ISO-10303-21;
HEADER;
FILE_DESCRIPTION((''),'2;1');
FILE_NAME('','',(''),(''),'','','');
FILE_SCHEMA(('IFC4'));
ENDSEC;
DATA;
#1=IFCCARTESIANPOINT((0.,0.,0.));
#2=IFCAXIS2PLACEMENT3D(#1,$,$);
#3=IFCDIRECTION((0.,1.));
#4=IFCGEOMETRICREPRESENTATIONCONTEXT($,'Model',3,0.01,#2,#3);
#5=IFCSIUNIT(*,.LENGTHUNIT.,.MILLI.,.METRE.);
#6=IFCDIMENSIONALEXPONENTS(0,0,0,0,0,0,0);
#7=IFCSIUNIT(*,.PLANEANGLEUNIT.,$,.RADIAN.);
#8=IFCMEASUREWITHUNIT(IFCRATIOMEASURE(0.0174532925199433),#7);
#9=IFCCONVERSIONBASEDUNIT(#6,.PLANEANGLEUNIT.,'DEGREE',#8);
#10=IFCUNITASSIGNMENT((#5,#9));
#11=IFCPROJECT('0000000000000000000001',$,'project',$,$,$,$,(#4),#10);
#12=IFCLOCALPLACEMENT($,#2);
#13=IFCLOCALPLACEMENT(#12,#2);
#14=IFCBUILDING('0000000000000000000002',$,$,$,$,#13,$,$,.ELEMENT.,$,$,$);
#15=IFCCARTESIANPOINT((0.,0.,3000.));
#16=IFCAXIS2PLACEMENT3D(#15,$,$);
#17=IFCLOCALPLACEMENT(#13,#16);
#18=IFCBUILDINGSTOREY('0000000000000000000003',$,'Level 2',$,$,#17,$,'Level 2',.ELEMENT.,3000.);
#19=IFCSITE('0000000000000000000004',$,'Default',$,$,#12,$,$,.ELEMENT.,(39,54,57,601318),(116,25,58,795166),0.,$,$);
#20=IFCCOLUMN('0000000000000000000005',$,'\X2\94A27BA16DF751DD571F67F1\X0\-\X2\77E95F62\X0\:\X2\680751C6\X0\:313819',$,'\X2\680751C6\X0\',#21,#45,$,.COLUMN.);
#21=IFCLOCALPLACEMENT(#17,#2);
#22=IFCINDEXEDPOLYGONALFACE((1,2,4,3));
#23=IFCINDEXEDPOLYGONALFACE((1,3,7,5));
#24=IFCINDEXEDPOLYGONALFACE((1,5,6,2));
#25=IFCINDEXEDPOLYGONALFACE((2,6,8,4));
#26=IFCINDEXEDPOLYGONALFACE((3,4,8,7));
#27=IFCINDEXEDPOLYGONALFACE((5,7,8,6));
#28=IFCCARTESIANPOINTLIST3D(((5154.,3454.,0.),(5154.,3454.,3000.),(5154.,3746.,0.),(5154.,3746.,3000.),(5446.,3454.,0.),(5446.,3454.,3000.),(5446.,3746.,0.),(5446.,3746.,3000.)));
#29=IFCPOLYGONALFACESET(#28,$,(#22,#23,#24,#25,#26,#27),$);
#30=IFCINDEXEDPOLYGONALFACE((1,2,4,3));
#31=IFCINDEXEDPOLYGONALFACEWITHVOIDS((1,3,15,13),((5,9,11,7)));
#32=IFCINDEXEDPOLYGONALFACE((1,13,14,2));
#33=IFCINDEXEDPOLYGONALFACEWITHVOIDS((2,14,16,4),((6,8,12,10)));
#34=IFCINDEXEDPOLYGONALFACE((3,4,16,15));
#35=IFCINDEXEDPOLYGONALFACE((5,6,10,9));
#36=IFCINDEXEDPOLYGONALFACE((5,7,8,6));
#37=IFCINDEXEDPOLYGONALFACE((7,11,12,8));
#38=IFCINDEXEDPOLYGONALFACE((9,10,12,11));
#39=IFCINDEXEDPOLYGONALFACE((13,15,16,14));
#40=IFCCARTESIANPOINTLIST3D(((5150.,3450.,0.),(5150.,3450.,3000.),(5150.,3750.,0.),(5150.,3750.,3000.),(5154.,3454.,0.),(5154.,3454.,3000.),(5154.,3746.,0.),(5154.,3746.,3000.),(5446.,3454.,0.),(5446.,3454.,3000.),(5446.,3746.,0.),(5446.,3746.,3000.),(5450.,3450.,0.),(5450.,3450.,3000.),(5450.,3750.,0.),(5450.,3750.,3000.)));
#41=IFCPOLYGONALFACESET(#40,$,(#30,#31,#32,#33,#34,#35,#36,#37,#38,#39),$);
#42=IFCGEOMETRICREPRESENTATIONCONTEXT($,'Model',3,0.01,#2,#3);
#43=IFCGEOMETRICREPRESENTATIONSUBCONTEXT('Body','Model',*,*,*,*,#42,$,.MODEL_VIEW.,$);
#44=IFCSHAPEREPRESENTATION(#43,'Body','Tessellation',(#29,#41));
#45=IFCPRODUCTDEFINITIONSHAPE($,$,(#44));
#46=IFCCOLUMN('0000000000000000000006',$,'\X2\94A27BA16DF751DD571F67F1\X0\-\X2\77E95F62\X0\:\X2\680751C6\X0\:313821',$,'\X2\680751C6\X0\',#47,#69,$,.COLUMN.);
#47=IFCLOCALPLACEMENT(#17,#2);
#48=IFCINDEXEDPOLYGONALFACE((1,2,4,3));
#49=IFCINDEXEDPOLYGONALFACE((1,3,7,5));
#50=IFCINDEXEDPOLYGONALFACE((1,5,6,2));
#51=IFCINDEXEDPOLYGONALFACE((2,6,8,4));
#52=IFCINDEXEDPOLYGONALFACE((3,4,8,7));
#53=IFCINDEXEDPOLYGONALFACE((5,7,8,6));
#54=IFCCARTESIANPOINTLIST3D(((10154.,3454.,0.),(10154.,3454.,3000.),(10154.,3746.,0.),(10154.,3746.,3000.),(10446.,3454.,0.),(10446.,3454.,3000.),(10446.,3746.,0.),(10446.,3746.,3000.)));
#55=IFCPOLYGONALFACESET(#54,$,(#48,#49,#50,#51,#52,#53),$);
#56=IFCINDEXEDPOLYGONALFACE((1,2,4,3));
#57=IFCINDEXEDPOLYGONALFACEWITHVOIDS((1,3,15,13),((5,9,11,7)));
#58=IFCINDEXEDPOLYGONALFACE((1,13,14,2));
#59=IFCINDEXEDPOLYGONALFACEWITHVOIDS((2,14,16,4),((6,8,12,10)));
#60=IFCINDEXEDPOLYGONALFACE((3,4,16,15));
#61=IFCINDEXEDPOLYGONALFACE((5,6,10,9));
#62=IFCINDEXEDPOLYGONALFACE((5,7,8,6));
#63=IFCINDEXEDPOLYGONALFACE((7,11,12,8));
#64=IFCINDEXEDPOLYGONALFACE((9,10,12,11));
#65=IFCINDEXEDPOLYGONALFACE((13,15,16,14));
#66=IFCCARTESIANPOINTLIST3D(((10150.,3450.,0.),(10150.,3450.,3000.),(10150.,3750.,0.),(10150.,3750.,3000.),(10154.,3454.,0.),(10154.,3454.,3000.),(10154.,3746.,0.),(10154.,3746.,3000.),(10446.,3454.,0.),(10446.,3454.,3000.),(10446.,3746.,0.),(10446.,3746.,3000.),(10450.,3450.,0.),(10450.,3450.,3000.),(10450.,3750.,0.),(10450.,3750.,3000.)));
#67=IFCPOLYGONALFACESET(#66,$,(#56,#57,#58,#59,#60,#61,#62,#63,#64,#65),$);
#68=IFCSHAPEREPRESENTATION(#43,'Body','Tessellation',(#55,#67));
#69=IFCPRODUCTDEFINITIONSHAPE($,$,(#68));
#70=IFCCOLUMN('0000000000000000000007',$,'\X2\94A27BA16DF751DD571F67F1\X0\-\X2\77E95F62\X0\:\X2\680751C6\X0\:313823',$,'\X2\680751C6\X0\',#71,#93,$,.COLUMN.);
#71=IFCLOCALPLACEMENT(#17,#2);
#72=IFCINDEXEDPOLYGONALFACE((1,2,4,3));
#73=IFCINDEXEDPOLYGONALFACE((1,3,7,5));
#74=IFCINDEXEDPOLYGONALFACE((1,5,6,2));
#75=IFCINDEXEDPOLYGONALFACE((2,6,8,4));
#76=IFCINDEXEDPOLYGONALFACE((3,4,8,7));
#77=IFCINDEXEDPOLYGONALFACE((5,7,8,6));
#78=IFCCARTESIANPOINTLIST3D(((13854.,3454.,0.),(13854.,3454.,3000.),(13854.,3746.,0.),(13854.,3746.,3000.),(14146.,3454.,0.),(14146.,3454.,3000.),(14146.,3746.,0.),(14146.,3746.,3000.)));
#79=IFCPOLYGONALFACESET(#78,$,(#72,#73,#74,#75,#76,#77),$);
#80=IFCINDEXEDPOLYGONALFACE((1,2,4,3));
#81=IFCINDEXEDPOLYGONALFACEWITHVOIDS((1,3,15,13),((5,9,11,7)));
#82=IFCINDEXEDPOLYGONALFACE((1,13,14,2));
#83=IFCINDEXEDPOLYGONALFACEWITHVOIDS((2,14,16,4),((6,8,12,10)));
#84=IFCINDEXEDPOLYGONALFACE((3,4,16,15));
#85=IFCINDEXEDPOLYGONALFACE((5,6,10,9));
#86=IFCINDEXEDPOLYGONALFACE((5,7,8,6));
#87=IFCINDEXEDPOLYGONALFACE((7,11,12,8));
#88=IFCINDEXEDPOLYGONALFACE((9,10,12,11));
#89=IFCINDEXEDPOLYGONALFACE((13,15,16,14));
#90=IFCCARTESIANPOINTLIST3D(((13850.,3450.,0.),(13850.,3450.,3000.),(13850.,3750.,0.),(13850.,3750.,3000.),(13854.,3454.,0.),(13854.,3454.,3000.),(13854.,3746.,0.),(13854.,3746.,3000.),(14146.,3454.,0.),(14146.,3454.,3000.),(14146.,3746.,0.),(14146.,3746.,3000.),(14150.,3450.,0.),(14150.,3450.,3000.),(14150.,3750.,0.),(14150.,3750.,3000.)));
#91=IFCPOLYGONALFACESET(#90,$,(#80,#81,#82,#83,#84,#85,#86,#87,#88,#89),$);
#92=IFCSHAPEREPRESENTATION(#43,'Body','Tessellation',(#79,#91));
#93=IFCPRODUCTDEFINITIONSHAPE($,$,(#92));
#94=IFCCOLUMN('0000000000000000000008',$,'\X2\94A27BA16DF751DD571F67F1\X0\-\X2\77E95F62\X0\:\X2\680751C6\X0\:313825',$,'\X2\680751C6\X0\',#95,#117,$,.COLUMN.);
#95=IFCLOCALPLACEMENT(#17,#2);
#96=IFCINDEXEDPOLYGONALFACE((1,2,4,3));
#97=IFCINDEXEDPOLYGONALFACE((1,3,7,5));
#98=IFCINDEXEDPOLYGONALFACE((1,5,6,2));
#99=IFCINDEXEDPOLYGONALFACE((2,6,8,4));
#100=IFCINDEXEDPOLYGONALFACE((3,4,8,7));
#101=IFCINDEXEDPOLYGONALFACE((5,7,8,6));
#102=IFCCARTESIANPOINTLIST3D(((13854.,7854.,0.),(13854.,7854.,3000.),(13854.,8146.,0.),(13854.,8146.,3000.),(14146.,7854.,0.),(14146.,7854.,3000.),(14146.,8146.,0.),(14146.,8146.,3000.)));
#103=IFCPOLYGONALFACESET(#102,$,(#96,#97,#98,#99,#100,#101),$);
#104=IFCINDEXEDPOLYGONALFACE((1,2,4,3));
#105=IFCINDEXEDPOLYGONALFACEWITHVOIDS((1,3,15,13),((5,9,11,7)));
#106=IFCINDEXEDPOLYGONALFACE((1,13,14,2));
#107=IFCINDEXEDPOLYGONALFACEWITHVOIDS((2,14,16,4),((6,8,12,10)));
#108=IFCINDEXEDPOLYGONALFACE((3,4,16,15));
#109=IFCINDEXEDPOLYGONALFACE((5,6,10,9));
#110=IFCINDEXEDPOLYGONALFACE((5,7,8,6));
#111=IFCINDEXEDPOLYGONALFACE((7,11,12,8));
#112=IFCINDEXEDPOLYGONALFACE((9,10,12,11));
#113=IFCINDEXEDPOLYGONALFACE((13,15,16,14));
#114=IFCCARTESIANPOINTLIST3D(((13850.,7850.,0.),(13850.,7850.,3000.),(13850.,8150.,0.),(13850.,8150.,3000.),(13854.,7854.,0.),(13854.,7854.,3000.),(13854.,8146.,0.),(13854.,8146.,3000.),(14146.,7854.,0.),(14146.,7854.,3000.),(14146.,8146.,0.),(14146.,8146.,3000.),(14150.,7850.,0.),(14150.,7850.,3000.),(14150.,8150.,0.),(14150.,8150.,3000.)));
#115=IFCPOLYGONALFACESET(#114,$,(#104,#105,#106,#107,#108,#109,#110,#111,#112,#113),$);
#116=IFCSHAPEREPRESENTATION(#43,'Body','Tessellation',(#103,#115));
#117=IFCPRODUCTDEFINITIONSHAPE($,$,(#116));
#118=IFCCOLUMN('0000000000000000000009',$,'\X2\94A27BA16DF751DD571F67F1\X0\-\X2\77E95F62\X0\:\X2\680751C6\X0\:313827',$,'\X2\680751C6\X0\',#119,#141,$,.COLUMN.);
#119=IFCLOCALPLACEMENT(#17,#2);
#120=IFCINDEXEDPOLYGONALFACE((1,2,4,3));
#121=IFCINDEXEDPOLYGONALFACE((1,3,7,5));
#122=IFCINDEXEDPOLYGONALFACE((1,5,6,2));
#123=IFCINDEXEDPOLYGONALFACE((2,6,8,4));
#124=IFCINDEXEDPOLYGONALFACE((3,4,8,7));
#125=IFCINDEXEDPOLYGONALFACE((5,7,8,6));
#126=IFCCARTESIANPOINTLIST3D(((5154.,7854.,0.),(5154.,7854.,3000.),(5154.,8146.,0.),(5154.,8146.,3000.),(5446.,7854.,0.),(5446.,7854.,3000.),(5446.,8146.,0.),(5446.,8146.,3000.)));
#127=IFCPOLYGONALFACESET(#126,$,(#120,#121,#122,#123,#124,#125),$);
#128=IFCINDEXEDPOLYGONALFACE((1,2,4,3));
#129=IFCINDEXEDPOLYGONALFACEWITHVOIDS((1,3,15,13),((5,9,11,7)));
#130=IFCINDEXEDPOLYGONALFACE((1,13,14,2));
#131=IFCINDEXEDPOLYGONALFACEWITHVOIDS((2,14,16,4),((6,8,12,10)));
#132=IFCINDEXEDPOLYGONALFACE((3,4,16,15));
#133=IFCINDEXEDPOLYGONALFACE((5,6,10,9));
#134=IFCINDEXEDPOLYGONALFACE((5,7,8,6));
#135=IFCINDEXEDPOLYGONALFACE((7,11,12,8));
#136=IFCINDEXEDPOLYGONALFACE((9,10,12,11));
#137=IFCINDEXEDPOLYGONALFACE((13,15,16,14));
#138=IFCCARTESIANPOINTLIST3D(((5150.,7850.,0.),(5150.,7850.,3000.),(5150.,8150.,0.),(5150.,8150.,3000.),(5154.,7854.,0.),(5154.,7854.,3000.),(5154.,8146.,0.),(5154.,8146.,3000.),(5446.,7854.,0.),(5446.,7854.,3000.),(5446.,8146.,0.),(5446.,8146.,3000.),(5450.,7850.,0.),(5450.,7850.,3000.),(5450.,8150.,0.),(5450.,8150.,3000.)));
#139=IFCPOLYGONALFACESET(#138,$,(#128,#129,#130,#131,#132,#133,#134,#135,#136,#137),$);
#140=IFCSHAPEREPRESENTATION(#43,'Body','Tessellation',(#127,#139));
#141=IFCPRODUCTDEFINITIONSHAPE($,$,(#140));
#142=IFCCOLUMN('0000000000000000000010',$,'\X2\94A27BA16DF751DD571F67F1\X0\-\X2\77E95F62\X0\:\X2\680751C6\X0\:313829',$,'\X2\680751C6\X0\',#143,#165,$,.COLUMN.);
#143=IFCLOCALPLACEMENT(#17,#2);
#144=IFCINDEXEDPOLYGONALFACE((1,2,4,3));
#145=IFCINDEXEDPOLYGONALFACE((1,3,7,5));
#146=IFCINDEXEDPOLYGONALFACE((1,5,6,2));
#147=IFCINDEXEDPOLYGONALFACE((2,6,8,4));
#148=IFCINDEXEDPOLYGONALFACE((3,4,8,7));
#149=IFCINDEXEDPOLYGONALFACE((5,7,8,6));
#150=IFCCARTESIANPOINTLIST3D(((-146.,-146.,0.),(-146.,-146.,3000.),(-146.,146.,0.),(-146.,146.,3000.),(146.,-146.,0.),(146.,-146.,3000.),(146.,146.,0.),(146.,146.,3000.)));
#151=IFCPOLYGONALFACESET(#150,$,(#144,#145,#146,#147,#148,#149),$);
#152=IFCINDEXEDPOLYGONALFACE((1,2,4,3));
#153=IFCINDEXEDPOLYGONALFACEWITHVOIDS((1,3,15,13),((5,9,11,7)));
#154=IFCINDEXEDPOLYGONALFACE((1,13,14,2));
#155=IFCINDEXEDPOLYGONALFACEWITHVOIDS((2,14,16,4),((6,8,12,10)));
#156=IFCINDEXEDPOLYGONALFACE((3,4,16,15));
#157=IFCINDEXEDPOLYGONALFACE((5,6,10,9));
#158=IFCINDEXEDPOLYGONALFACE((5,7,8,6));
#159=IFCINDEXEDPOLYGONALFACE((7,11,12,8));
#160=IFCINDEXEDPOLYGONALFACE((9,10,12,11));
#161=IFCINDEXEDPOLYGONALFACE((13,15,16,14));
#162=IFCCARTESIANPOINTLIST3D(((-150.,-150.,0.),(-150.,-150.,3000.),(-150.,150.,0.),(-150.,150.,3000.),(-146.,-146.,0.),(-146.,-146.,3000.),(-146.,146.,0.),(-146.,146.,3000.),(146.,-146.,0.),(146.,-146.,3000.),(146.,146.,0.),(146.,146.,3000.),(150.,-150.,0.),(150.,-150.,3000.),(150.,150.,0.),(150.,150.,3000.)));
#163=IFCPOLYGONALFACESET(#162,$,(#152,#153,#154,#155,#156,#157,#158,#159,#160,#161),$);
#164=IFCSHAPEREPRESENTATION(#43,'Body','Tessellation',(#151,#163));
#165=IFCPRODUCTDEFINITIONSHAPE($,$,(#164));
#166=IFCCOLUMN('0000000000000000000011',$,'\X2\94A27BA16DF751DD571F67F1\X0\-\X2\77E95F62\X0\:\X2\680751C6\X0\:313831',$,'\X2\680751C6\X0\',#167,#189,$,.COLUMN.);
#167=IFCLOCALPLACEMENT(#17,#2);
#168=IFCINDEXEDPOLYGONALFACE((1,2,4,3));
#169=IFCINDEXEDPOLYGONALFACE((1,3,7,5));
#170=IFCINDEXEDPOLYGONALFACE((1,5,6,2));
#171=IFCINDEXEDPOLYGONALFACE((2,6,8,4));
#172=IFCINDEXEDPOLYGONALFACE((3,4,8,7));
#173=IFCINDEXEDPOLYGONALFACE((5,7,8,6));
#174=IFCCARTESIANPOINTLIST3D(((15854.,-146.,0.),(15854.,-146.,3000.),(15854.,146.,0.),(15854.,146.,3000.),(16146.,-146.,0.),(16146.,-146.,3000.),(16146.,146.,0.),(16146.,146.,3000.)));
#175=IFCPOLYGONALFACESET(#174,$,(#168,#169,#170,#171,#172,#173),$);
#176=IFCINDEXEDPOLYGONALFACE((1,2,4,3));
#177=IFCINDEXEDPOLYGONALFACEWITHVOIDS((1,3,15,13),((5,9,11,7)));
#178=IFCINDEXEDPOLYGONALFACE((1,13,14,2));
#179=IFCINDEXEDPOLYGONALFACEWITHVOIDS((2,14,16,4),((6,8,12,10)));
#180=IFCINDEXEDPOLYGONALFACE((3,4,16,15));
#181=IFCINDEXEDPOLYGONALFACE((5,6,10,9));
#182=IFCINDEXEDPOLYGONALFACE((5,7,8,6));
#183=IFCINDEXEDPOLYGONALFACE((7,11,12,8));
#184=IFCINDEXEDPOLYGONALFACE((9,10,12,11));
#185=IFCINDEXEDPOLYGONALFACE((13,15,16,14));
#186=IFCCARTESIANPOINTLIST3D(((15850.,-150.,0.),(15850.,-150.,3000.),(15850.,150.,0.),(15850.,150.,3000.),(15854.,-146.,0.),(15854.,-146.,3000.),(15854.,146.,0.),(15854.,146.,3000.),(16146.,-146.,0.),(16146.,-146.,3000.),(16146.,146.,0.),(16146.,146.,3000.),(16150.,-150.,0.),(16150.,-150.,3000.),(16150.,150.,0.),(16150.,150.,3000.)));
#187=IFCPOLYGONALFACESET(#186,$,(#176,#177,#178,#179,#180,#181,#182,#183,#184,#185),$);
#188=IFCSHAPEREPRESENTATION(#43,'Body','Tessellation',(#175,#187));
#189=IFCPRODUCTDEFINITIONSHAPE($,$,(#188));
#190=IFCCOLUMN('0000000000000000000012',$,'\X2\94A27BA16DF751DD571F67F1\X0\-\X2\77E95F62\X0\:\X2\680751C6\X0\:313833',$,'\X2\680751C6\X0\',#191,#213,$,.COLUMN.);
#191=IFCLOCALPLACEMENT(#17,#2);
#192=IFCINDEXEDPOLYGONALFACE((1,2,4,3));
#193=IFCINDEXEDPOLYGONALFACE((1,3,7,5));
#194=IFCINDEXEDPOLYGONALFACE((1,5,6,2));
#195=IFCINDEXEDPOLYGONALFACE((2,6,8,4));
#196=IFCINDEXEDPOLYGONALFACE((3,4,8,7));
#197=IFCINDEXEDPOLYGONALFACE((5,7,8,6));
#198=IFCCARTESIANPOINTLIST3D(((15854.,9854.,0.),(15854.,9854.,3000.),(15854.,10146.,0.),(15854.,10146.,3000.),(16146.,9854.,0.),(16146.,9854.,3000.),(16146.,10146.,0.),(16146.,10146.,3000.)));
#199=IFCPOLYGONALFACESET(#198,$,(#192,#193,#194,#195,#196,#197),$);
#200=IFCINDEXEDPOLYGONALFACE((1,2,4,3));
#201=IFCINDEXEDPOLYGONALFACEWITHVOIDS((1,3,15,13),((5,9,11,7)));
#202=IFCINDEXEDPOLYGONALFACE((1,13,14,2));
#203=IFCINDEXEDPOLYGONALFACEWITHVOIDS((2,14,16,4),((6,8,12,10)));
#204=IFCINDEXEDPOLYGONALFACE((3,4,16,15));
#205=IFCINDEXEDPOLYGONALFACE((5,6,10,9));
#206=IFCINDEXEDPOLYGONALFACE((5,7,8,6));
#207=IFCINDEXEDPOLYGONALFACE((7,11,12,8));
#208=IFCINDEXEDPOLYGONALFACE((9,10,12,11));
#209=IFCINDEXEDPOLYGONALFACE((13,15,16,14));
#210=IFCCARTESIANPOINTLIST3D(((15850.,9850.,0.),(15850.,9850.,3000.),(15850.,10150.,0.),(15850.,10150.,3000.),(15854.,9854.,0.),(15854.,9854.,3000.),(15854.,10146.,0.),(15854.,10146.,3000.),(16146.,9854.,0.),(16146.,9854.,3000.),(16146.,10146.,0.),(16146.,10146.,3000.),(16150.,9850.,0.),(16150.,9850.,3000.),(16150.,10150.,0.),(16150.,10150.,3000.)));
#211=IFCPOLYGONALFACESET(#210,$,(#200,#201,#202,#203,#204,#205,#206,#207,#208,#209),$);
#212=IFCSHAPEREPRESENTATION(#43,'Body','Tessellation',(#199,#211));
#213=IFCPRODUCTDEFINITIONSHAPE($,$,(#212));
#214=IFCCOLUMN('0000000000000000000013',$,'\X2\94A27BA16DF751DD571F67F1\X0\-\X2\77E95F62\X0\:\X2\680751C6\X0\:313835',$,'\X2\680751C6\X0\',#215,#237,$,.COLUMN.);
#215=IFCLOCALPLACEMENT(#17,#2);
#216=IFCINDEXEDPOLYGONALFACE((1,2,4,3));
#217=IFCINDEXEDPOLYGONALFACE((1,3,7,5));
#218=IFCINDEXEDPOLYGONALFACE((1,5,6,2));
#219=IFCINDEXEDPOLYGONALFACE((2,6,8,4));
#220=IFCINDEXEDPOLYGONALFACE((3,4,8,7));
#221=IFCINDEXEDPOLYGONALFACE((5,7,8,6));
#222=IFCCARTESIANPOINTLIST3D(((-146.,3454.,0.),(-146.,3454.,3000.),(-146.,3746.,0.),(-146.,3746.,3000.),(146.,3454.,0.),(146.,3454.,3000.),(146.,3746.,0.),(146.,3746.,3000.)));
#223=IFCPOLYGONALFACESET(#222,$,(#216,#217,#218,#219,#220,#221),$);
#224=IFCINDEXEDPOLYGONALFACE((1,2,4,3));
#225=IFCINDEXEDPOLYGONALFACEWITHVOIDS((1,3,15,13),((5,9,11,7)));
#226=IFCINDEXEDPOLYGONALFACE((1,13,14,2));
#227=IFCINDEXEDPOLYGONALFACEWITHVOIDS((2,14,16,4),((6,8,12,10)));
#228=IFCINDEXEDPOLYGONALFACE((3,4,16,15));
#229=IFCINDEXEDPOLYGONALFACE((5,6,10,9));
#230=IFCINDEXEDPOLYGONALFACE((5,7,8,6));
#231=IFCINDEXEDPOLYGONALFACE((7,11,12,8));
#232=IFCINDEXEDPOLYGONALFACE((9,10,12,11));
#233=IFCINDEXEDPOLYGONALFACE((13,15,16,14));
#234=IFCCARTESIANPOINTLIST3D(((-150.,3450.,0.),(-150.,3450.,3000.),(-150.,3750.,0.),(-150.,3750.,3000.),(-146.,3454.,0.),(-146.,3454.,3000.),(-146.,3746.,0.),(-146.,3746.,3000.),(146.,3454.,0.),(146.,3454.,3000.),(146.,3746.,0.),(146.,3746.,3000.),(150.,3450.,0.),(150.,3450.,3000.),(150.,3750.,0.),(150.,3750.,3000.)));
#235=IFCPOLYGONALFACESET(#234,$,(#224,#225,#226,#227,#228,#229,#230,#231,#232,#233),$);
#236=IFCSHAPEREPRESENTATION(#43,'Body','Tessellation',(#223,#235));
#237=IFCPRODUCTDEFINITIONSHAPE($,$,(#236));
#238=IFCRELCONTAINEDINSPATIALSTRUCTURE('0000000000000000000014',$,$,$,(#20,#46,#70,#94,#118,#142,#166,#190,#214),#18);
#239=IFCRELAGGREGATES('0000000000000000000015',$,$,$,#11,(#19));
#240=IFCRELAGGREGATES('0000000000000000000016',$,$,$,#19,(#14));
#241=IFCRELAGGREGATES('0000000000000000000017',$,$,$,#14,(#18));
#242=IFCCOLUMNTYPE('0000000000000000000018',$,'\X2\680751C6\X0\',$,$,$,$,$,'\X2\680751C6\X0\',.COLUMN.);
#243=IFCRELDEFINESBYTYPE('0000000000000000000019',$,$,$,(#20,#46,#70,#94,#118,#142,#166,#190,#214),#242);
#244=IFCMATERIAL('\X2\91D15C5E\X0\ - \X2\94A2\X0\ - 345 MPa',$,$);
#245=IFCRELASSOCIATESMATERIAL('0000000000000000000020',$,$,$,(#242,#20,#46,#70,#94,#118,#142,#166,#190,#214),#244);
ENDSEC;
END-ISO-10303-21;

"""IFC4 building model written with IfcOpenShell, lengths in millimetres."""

from ifc_helpers import new_model, entity, si_unit, converted_unit, direction, frame, origin, origin_2d_with_axis, place, context, subcontext, project, spatial, polyline, rectangle, outline, extrude, source, transform, mapped, material, type_object, type_shapes, element, save


model = new_model("IFC4")

# Units and contexts
model_context_1 = context("Model", 3, precision=0.01, world=origin(), true_north=direction((0.0, 1.0)))
model_context_2 = context("Model", 3, precision=0.01, world=origin(), true_north=direction((0.0, 1.0)))
body_context = subcontext(model_context_2, "Body", "Model", "MODEL_VIEW")
ifc_project = project(units=[si_unit("LENGTHUNIT", "METRE", prefix="MILLI"), converted_unit("PLANEANGLEUNIT", "DEGREE", entity("IfcRatioMeasure", 0.0174532925199433), si_unit("PLANEANGLEUNIT", "RADIAN"), dimensions=[0, 0, 0, 0, 0, 0, 0])], contexts=[model_context_1])

# Site, building, storey
site_placement = place(None, origin())
site = spatial("IfcSite", under=ifc_project, at=site_placement, Name="Default", CompositionType="ELEMENT", RefLatitude=(39, 54, 57, 601318), RefLongitude=(116, 25, 58, 795166), RefElevation=0.0)
building_placement = place(site_placement, origin())
building = spatial("IfcBuilding", under=site, at=building_placement, CompositionType="ELEMENT")
storey_placement = place(building_placement, frame((0.0, 0.0, 3000.0)))
storey = spatial("IfcBuildingStorey", under=building, at=storey_placement, Name="Level 2", LongName="Level 2", CompositionType="ELEMENT", Elevation=3000.0)

# Columns
ifc_material = material(Name="金属 - 钢 - 345 MPa")
column_type = type_object("IfcColumnType", Name="标准", ElementType="标准", PredefinedType="COLUMN", material=ifc_material)
shared_shape = source(origin(), body_context, "Body", "SweptSolid", [
    extrude(rectangle(XDim=292.0, YDim=292.0, at=origin_2d_with_axis()), frame((150.0, 150.0, 0.0), z_axis=(0.0, 0.0, 1.0), x_axis=(-1.0, 0.0, 0.0)), (0.0, 0.0, 1.0), 3000.0),
    extrude(outline(polyline([(-150.0, -150.0), (150.0, -150.0), (150.0, 150.0), (-150.0, 150.0), (-150.0, -150.0)]), holes=[polyline([(-146.0, -146.0), (-146.0, 146.0), (146.0, 146.0), (146.0, -146.0), (-146.0, -146.0)])]), frame((150.0, 150.0, 0.0), z_axis=(0.0, 0.0, 1.0), x_axis=(-1.0, 0.0, 0.0)), (0.0, 0.0, 1.0), 3000.0),
])
type_shapes(column_type, [shared_shape])
for number, where, name in (
    (1, (5150.0, 3450.0, 0.0), "钢管混凝土柱-矩形:标准:313819"),
    (2, (10150.0, 3450.0, 0.0), "钢管混凝土柱-矩形:标准:313821"),
    (3, (13850.0, 3450.0, 0.0), "钢管混凝土柱-矩形:标准:313823"),
    (4, (13850.0, 7850.0, 0.0), "钢管混凝土柱-矩形:标准:313825"),
    (5, (5150.0, 7850.0, 0.0), "钢管混凝土柱-矩形:标准:313827"),
    (6, (-150.0, -150.0, 0.0), "钢管混凝土柱-矩形:标准:313829"),
    (7, (15850.0, -150.0, 0.0), "钢管混凝土柱-矩形:标准:313831"),
    (8, (15850.0, 9850.0, 0.0), "钢管混凝土柱-矩形:标准:313833"),
    (9, (-150.0, 3450.0, 0.0), "钢管混凝土柱-矩形:标准:313835"),
):
    element("IfcColumn", number, at=place(storey_placement, frame(where)), inside=storey, type_object=column_type, material=ifc_material, Name=name, ObjectType="标准", PredefinedType="COLUMN", context=body_context, shape_type="MappedRepresentation", body=[
        mapped(shared_shape, transform((0.0, 0.0, 0.0), scale=1.0)),
    ])

save(model, "model.ifc")
